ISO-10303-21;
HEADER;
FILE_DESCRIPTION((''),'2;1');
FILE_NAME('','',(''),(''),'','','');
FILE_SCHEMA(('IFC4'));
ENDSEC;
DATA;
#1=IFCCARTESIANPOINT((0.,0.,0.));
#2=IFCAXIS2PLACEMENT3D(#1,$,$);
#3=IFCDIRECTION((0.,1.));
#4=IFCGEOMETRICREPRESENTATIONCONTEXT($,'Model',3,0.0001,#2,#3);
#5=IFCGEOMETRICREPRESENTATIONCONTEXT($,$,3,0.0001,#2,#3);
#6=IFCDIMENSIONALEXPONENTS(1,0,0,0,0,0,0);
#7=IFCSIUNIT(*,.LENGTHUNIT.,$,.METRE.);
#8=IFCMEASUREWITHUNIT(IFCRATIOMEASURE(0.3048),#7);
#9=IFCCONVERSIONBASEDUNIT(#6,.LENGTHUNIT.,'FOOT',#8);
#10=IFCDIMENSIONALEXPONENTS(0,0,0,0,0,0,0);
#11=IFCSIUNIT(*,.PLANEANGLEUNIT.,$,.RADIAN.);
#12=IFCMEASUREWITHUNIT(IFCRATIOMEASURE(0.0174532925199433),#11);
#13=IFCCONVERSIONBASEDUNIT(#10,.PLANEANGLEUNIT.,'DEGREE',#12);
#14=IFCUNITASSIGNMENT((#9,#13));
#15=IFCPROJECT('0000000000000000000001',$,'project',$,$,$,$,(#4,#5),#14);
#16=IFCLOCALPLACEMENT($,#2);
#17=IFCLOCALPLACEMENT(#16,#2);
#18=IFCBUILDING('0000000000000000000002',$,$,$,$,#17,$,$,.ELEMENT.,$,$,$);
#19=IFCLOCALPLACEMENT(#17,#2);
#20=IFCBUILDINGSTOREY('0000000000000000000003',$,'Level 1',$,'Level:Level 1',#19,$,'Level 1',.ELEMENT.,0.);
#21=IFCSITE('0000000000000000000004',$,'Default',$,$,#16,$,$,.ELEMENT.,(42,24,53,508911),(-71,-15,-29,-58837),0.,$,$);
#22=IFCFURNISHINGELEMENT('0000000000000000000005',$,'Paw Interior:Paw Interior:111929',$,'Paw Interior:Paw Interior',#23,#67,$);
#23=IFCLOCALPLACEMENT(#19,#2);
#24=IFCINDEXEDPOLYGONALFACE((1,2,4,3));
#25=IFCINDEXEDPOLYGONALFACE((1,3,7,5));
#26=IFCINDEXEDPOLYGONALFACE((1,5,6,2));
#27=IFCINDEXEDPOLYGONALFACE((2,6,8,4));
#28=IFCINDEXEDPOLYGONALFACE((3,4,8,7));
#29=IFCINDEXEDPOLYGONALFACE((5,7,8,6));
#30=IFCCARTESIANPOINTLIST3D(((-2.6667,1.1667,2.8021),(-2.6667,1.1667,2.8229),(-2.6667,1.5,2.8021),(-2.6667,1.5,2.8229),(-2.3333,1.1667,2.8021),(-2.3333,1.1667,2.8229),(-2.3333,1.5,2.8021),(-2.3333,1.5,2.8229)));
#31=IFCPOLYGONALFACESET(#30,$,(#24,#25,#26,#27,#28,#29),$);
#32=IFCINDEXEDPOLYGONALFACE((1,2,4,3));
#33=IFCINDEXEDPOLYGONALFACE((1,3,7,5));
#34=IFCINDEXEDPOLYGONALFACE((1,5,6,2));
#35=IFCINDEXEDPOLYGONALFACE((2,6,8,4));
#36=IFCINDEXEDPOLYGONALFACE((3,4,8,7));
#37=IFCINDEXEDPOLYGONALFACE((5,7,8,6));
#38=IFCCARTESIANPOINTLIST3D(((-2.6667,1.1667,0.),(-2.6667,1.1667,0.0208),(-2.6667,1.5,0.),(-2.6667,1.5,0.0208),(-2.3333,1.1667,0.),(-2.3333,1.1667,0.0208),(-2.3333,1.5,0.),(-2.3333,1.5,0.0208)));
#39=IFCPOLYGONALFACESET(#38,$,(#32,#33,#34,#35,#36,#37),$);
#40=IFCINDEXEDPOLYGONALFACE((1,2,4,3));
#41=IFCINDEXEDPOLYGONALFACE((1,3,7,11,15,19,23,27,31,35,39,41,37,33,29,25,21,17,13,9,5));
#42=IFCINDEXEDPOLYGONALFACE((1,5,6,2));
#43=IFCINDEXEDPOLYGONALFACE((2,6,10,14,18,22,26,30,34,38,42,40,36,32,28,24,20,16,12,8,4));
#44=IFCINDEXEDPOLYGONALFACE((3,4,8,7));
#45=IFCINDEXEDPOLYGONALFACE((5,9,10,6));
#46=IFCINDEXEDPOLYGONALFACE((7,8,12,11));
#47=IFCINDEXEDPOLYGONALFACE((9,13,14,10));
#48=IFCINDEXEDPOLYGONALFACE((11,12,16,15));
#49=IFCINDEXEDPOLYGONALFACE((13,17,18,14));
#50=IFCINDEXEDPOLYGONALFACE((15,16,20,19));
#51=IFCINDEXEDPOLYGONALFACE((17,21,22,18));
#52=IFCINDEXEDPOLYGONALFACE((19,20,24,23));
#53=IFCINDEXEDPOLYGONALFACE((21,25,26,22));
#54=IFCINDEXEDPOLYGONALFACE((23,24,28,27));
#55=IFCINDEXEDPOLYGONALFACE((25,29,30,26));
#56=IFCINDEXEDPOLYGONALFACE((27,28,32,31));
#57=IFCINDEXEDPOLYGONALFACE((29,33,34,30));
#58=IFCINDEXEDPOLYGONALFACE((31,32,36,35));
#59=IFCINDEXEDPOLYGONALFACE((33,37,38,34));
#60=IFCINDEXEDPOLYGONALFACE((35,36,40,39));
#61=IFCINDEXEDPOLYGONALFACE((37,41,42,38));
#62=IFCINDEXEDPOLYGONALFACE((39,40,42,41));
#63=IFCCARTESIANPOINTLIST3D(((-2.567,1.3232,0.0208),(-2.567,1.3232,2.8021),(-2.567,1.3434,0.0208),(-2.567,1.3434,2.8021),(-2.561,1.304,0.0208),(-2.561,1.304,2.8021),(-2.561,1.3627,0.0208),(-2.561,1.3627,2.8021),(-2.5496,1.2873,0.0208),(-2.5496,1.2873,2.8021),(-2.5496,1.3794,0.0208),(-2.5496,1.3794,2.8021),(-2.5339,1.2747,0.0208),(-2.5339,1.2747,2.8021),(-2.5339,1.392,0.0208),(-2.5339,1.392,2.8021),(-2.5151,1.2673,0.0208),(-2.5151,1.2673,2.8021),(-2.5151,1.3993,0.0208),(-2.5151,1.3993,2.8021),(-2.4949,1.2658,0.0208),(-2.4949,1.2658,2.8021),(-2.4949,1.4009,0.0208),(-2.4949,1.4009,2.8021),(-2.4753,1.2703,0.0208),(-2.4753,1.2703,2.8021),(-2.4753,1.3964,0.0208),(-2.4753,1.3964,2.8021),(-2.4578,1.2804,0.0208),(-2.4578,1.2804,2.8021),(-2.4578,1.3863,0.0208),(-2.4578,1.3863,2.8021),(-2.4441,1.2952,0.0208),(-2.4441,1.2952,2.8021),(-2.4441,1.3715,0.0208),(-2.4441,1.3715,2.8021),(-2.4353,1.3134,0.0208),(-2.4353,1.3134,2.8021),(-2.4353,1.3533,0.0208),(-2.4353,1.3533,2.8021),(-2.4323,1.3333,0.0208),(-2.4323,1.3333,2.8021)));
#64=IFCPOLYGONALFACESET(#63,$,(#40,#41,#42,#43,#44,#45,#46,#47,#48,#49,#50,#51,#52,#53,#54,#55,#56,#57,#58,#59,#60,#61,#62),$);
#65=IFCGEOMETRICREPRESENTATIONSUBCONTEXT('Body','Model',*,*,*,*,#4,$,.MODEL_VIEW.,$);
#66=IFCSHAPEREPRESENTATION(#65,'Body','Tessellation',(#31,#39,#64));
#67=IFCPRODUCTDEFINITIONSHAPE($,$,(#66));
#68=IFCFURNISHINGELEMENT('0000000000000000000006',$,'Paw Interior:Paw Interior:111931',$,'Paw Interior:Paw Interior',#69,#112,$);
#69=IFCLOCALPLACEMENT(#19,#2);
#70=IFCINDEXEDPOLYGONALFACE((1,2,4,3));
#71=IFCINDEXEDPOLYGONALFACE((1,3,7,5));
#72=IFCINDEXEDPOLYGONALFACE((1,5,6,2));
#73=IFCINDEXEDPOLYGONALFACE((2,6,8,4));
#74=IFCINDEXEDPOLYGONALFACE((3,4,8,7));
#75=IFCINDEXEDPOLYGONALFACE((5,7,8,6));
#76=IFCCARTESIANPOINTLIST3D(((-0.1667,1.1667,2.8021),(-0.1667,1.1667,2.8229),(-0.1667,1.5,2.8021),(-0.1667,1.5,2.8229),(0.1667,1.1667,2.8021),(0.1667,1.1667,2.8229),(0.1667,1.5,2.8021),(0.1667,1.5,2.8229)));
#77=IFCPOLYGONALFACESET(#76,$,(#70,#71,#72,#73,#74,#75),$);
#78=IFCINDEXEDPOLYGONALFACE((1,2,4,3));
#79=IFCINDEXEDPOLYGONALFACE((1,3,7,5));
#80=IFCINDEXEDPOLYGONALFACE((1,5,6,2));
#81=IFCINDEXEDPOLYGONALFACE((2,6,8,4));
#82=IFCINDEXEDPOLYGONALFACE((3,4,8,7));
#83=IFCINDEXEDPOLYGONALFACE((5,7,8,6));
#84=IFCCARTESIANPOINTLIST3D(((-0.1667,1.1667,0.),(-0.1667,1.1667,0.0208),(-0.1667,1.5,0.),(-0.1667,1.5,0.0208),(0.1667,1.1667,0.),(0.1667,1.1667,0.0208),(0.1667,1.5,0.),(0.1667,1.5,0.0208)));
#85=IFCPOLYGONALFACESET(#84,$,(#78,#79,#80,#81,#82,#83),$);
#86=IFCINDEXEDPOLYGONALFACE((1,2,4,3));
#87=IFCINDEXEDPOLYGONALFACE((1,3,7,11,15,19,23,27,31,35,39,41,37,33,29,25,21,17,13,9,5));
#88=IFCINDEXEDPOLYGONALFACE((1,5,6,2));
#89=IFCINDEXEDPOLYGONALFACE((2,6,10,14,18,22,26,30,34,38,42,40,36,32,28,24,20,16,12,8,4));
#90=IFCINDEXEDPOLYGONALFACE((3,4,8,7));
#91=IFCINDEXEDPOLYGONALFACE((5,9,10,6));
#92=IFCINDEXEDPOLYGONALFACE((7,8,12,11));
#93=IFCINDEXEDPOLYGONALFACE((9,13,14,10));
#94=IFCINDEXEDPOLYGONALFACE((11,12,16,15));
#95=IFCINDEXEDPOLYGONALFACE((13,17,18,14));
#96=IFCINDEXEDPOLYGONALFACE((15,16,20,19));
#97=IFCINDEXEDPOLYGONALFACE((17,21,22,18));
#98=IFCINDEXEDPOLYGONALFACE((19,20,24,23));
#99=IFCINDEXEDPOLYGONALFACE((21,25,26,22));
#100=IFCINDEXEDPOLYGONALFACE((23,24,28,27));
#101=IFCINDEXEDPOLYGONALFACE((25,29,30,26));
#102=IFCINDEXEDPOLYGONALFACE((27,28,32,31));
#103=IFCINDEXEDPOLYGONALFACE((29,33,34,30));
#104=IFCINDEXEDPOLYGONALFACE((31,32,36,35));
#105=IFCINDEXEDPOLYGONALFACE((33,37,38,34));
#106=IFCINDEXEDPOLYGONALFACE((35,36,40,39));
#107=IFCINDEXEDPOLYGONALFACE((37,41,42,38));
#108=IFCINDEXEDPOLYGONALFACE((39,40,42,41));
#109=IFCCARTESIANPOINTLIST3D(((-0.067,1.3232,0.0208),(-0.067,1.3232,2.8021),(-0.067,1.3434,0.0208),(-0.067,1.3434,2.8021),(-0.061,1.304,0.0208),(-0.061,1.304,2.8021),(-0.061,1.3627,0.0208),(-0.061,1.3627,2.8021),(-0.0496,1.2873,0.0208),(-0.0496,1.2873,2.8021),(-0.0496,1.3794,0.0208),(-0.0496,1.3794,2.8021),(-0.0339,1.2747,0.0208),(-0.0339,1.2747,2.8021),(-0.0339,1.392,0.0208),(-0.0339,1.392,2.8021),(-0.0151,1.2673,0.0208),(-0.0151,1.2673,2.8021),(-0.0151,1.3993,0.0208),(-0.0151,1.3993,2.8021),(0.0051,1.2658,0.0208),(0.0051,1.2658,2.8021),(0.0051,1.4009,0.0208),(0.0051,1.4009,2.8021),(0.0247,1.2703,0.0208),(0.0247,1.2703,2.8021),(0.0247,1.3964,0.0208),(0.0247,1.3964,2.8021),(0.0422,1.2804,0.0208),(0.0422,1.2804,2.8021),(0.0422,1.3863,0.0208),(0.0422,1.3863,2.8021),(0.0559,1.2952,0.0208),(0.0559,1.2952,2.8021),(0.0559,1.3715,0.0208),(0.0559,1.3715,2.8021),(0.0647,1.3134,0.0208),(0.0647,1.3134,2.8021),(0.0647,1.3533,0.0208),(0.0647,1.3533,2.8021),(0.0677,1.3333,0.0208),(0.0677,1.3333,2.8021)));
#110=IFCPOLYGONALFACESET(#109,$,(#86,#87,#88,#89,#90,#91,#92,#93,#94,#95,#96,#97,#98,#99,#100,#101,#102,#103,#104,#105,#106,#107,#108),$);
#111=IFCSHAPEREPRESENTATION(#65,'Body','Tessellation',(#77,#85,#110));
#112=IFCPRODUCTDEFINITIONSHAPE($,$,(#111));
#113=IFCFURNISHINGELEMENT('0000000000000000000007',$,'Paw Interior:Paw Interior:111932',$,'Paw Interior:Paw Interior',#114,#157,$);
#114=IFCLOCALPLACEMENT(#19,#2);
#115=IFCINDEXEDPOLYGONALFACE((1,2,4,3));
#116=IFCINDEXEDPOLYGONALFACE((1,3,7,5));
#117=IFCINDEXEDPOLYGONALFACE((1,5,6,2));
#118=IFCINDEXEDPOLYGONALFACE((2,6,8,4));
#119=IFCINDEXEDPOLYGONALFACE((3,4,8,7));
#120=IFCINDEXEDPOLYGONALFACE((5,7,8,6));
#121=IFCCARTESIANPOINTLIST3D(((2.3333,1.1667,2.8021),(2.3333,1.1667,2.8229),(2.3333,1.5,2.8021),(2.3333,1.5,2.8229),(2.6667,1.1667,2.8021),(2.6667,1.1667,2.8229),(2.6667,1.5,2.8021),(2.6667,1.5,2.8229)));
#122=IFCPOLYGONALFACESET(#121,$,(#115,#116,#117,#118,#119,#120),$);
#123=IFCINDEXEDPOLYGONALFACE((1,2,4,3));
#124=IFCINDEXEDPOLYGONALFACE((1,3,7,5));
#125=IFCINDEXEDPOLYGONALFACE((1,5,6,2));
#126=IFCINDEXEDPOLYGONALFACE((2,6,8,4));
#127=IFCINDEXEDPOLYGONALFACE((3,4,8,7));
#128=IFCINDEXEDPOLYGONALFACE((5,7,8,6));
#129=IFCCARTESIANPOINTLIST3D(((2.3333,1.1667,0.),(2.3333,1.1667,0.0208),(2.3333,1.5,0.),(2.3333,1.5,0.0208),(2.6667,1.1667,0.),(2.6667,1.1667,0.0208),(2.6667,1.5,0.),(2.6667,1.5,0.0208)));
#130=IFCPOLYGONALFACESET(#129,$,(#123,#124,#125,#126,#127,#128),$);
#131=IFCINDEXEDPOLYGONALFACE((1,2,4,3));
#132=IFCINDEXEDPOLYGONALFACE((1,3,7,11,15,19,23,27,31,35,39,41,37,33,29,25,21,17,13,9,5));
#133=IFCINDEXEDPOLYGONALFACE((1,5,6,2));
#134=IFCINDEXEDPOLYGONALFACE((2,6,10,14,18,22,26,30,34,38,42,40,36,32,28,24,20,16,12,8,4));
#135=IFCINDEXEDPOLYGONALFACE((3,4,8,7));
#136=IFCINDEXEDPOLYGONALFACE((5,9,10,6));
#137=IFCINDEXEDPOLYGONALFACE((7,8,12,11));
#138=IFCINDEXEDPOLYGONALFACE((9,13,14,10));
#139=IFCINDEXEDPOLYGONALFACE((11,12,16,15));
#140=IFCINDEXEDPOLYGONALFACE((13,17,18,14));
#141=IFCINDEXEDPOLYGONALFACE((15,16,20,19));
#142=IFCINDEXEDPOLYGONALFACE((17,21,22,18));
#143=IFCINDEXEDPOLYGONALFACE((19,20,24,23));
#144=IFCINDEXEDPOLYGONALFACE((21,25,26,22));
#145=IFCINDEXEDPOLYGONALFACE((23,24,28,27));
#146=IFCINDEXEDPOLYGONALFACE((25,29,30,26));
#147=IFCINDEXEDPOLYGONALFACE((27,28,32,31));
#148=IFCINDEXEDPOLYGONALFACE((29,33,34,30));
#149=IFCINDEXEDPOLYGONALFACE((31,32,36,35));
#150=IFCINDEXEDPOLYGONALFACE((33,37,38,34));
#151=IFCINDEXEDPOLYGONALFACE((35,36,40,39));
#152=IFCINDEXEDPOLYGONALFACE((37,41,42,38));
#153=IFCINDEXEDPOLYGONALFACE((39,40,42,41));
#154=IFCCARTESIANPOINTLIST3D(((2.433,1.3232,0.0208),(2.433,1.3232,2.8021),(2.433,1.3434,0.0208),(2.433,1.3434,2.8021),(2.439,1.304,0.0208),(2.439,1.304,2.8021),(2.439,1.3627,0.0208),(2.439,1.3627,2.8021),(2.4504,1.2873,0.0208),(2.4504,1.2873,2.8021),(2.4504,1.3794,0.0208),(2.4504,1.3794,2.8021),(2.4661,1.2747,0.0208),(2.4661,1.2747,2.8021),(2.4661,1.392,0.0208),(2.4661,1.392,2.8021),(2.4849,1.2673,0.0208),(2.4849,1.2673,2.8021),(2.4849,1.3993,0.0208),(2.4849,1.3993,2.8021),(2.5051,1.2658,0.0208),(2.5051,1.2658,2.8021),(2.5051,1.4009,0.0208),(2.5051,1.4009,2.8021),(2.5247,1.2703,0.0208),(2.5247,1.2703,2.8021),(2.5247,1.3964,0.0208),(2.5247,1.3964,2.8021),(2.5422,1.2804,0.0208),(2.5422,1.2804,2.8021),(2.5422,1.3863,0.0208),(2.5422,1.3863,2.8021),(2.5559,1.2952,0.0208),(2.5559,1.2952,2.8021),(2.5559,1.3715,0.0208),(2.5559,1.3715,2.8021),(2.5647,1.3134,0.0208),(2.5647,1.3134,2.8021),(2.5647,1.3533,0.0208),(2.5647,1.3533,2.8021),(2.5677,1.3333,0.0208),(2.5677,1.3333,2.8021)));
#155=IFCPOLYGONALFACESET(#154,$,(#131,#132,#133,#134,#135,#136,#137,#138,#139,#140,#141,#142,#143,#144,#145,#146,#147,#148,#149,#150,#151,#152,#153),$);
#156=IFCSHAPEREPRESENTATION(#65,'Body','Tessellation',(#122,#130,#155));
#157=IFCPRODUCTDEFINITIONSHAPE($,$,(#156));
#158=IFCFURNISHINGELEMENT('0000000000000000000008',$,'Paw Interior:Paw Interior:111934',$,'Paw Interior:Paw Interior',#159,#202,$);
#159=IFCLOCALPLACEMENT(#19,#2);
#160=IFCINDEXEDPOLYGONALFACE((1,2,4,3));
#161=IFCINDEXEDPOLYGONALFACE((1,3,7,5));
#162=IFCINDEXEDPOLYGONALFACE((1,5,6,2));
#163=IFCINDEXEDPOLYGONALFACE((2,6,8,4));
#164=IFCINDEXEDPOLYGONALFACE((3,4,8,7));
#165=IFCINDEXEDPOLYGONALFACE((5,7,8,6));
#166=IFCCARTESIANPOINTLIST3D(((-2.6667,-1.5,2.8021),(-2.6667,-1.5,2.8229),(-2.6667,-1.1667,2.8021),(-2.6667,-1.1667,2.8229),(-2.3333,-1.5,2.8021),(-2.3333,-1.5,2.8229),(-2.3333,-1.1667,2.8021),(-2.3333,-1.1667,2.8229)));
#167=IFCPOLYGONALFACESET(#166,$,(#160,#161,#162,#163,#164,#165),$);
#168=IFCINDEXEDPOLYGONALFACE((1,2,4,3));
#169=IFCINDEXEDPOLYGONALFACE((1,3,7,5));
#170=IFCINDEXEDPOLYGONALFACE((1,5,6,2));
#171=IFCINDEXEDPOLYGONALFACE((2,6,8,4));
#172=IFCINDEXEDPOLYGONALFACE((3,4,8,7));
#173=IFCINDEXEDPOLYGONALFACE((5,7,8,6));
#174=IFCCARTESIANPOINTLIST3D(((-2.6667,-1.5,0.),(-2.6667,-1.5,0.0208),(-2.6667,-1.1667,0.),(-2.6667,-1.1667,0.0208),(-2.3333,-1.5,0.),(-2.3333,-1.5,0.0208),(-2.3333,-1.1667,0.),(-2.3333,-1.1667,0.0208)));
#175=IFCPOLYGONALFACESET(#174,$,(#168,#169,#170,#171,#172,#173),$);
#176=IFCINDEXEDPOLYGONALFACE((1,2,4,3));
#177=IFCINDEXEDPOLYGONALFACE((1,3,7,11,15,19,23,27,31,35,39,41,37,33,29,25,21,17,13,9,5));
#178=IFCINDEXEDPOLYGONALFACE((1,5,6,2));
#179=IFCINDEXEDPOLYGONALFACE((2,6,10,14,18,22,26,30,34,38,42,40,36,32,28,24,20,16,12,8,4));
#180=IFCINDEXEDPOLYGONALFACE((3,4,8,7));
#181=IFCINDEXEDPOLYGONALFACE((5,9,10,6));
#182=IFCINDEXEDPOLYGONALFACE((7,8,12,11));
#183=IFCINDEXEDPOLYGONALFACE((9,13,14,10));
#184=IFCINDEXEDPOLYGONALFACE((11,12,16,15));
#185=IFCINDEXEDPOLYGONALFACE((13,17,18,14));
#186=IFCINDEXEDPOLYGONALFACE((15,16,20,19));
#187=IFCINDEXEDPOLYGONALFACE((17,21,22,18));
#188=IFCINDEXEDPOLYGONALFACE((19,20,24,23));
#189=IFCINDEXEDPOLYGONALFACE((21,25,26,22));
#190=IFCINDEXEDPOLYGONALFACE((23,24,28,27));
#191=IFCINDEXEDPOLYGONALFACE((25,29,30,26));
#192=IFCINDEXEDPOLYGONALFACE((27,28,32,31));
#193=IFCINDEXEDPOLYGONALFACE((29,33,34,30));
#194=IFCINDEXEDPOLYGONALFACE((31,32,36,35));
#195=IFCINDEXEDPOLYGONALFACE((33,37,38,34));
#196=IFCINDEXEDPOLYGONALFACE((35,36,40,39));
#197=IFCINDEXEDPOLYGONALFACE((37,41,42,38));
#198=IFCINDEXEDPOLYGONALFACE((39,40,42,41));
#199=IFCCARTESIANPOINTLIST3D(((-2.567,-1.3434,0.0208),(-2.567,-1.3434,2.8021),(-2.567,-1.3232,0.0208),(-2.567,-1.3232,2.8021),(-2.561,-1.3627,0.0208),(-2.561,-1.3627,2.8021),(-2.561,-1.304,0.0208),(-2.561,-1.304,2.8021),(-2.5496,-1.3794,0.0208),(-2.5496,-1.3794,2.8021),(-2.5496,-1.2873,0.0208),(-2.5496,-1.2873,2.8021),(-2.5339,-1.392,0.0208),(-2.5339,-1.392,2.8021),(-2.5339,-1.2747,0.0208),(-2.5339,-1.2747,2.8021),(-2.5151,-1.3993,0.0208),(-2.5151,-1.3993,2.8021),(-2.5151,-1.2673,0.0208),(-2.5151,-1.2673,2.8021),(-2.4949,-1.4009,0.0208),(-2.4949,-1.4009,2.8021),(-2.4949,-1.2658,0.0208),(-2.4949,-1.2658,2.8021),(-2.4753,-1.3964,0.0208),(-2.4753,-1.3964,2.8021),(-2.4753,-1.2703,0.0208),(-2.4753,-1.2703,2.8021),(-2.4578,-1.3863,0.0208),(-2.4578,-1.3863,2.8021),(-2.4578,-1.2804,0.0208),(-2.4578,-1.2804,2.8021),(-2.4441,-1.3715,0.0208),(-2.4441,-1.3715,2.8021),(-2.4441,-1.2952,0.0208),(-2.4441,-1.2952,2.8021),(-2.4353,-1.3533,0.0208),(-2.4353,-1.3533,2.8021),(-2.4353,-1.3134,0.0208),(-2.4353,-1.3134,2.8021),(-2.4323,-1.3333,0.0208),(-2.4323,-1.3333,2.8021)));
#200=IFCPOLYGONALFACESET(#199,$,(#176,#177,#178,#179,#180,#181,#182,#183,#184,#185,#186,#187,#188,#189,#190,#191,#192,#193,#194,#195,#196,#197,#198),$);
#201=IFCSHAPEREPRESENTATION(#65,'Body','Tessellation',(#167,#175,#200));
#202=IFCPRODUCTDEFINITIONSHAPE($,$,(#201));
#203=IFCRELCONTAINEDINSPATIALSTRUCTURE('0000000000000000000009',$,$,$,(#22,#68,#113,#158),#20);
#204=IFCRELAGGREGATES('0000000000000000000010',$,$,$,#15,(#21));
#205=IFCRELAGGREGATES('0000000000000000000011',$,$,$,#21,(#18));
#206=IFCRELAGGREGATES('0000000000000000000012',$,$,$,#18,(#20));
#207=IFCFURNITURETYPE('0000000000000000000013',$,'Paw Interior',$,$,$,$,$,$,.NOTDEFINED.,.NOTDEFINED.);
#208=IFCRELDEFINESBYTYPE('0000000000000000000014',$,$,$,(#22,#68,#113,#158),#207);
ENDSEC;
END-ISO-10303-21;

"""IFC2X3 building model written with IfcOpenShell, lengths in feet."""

from ifc_helpers import new_model, entity, si_unit, converted_unit, direction, frame, frame_2d, origin, place, context, subcontext, project, spatial, rectangle, circle, extrude, source, transform, mapped, type_object, type_shapes, element, save


model = new_model("IFC2X3")

# Units and contexts
model_context = context("Model", 3, precision=0.0001, world=origin(), true_north=direction((0.0, 1.0)))
context_of_model = context(None, 3, precision=0.0001, world=origin(), true_north=direction((0.0, 1.0)))
body_context = subcontext(model_context, "Body", "Model", "MODEL_VIEW")
ifc_project = project(units=[converted_unit("LENGTHUNIT", "FOOT", entity("IfcRatioMeasure", 0.3048), si_unit("LENGTHUNIT", "METRE"), dimensions=[1, 0, 0, 0, 0, 0, 0]), converted_unit("PLANEANGLEUNIT", "DEGREE", entity("IfcRatioMeasure", 0.0174532925199433), si_unit("PLANEANGLEUNIT", "RADIAN"), dimensions=[0, 0, 0, 0, 0, 0, 0])], contexts=[model_context, context_of_model])

# Site, building, storey
site_placement = place(None, origin())
site = spatial("IfcSite", under=ifc_project, at=site_placement, Name="Default", CompositionType="ELEMENT", RefLatitude=(42, 24, 53, 508911), RefLongitude=(-71, -15, -29, -58837), RefElevation=0.0)
building_placement = place(site_placement, origin())
building = spatial("IfcBuilding", under=site, at=building_placement, CompositionType="ELEMENT")
storey_placement = place(building_placement, origin())
storey = spatial("IfcBuildingStorey", under=building, at=storey_placement, Name="Level 1", ObjectType="Level:Level 1", LongName="Level 1", CompositionType="ELEMENT", Elevation=0.0)

# Furnishing elements
furniture_type_1 = type_object("IfcFurnitureType", Name="Paw Interior")
shared_shape_1 = source(origin(), body_context, "Body", "SweptSolid", [
    extrude(rectangle(XDim=0.3333, YDim=0.3333, at=frame_2d((0.0, 0.0), x_axis=(1.0, 0.0))), frame((0.0, 0.0, 2.8021), z_axis=(0.0, 0.0, 1.0), x_axis=(-1.0, 0.0, 0.0)), (0.0, 0.0, 1.0), 0.0208),
    extrude(rectangle(XDim=0.3333, YDim=0.3333, at=frame_2d((0.0, 0.0), x_axis=(1.0, 0.0))), frame((0.0, 0.0, 0.0), z_axis=(0.0, 0.0, 1.0), x_axis=(-1.0, 0.0, 0.0)), (0.0, 0.0, 1.0), 0.0208),
    extrude(circle(Radius=0.0677, at=frame_2d((0.0, 0.0), x_axis=(1.0, 0.0))), frame((0.0, 0.0, 0.0208)), (0.0, 0.0, 1.0), 2.7812),
])
type_shapes(furniture_type_1, [shared_shape_1])
for number, where, name in (
    (1, (-2.5, 1.3333, 0.0), "Paw Interior:Paw Interior:111929"),
    (2, (0.0, 1.3333, 0.0), "Paw Interior:Paw Interior:111931"),
    (3, (2.5, 1.3333, 0.0), "Paw Interior:Paw Interior:111932"),
    (4, (-2.5, -1.3333, 0.0), "Paw Interior:Paw Interior:111934"),
):
    element("IfcFurnishingElement", number, at=place(storey_placement, frame(where)), inside=storey, type_object=furniture_type_1, Name=name, ObjectType="Paw Interior:Paw Interior", context=body_context, shape_type="MappedRepresentation", body=[
        mapped(shared_shape_1, transform((0.0, 0.0, 0.0), scale=1.0)),
    ])

save(model, "model.ifc")
